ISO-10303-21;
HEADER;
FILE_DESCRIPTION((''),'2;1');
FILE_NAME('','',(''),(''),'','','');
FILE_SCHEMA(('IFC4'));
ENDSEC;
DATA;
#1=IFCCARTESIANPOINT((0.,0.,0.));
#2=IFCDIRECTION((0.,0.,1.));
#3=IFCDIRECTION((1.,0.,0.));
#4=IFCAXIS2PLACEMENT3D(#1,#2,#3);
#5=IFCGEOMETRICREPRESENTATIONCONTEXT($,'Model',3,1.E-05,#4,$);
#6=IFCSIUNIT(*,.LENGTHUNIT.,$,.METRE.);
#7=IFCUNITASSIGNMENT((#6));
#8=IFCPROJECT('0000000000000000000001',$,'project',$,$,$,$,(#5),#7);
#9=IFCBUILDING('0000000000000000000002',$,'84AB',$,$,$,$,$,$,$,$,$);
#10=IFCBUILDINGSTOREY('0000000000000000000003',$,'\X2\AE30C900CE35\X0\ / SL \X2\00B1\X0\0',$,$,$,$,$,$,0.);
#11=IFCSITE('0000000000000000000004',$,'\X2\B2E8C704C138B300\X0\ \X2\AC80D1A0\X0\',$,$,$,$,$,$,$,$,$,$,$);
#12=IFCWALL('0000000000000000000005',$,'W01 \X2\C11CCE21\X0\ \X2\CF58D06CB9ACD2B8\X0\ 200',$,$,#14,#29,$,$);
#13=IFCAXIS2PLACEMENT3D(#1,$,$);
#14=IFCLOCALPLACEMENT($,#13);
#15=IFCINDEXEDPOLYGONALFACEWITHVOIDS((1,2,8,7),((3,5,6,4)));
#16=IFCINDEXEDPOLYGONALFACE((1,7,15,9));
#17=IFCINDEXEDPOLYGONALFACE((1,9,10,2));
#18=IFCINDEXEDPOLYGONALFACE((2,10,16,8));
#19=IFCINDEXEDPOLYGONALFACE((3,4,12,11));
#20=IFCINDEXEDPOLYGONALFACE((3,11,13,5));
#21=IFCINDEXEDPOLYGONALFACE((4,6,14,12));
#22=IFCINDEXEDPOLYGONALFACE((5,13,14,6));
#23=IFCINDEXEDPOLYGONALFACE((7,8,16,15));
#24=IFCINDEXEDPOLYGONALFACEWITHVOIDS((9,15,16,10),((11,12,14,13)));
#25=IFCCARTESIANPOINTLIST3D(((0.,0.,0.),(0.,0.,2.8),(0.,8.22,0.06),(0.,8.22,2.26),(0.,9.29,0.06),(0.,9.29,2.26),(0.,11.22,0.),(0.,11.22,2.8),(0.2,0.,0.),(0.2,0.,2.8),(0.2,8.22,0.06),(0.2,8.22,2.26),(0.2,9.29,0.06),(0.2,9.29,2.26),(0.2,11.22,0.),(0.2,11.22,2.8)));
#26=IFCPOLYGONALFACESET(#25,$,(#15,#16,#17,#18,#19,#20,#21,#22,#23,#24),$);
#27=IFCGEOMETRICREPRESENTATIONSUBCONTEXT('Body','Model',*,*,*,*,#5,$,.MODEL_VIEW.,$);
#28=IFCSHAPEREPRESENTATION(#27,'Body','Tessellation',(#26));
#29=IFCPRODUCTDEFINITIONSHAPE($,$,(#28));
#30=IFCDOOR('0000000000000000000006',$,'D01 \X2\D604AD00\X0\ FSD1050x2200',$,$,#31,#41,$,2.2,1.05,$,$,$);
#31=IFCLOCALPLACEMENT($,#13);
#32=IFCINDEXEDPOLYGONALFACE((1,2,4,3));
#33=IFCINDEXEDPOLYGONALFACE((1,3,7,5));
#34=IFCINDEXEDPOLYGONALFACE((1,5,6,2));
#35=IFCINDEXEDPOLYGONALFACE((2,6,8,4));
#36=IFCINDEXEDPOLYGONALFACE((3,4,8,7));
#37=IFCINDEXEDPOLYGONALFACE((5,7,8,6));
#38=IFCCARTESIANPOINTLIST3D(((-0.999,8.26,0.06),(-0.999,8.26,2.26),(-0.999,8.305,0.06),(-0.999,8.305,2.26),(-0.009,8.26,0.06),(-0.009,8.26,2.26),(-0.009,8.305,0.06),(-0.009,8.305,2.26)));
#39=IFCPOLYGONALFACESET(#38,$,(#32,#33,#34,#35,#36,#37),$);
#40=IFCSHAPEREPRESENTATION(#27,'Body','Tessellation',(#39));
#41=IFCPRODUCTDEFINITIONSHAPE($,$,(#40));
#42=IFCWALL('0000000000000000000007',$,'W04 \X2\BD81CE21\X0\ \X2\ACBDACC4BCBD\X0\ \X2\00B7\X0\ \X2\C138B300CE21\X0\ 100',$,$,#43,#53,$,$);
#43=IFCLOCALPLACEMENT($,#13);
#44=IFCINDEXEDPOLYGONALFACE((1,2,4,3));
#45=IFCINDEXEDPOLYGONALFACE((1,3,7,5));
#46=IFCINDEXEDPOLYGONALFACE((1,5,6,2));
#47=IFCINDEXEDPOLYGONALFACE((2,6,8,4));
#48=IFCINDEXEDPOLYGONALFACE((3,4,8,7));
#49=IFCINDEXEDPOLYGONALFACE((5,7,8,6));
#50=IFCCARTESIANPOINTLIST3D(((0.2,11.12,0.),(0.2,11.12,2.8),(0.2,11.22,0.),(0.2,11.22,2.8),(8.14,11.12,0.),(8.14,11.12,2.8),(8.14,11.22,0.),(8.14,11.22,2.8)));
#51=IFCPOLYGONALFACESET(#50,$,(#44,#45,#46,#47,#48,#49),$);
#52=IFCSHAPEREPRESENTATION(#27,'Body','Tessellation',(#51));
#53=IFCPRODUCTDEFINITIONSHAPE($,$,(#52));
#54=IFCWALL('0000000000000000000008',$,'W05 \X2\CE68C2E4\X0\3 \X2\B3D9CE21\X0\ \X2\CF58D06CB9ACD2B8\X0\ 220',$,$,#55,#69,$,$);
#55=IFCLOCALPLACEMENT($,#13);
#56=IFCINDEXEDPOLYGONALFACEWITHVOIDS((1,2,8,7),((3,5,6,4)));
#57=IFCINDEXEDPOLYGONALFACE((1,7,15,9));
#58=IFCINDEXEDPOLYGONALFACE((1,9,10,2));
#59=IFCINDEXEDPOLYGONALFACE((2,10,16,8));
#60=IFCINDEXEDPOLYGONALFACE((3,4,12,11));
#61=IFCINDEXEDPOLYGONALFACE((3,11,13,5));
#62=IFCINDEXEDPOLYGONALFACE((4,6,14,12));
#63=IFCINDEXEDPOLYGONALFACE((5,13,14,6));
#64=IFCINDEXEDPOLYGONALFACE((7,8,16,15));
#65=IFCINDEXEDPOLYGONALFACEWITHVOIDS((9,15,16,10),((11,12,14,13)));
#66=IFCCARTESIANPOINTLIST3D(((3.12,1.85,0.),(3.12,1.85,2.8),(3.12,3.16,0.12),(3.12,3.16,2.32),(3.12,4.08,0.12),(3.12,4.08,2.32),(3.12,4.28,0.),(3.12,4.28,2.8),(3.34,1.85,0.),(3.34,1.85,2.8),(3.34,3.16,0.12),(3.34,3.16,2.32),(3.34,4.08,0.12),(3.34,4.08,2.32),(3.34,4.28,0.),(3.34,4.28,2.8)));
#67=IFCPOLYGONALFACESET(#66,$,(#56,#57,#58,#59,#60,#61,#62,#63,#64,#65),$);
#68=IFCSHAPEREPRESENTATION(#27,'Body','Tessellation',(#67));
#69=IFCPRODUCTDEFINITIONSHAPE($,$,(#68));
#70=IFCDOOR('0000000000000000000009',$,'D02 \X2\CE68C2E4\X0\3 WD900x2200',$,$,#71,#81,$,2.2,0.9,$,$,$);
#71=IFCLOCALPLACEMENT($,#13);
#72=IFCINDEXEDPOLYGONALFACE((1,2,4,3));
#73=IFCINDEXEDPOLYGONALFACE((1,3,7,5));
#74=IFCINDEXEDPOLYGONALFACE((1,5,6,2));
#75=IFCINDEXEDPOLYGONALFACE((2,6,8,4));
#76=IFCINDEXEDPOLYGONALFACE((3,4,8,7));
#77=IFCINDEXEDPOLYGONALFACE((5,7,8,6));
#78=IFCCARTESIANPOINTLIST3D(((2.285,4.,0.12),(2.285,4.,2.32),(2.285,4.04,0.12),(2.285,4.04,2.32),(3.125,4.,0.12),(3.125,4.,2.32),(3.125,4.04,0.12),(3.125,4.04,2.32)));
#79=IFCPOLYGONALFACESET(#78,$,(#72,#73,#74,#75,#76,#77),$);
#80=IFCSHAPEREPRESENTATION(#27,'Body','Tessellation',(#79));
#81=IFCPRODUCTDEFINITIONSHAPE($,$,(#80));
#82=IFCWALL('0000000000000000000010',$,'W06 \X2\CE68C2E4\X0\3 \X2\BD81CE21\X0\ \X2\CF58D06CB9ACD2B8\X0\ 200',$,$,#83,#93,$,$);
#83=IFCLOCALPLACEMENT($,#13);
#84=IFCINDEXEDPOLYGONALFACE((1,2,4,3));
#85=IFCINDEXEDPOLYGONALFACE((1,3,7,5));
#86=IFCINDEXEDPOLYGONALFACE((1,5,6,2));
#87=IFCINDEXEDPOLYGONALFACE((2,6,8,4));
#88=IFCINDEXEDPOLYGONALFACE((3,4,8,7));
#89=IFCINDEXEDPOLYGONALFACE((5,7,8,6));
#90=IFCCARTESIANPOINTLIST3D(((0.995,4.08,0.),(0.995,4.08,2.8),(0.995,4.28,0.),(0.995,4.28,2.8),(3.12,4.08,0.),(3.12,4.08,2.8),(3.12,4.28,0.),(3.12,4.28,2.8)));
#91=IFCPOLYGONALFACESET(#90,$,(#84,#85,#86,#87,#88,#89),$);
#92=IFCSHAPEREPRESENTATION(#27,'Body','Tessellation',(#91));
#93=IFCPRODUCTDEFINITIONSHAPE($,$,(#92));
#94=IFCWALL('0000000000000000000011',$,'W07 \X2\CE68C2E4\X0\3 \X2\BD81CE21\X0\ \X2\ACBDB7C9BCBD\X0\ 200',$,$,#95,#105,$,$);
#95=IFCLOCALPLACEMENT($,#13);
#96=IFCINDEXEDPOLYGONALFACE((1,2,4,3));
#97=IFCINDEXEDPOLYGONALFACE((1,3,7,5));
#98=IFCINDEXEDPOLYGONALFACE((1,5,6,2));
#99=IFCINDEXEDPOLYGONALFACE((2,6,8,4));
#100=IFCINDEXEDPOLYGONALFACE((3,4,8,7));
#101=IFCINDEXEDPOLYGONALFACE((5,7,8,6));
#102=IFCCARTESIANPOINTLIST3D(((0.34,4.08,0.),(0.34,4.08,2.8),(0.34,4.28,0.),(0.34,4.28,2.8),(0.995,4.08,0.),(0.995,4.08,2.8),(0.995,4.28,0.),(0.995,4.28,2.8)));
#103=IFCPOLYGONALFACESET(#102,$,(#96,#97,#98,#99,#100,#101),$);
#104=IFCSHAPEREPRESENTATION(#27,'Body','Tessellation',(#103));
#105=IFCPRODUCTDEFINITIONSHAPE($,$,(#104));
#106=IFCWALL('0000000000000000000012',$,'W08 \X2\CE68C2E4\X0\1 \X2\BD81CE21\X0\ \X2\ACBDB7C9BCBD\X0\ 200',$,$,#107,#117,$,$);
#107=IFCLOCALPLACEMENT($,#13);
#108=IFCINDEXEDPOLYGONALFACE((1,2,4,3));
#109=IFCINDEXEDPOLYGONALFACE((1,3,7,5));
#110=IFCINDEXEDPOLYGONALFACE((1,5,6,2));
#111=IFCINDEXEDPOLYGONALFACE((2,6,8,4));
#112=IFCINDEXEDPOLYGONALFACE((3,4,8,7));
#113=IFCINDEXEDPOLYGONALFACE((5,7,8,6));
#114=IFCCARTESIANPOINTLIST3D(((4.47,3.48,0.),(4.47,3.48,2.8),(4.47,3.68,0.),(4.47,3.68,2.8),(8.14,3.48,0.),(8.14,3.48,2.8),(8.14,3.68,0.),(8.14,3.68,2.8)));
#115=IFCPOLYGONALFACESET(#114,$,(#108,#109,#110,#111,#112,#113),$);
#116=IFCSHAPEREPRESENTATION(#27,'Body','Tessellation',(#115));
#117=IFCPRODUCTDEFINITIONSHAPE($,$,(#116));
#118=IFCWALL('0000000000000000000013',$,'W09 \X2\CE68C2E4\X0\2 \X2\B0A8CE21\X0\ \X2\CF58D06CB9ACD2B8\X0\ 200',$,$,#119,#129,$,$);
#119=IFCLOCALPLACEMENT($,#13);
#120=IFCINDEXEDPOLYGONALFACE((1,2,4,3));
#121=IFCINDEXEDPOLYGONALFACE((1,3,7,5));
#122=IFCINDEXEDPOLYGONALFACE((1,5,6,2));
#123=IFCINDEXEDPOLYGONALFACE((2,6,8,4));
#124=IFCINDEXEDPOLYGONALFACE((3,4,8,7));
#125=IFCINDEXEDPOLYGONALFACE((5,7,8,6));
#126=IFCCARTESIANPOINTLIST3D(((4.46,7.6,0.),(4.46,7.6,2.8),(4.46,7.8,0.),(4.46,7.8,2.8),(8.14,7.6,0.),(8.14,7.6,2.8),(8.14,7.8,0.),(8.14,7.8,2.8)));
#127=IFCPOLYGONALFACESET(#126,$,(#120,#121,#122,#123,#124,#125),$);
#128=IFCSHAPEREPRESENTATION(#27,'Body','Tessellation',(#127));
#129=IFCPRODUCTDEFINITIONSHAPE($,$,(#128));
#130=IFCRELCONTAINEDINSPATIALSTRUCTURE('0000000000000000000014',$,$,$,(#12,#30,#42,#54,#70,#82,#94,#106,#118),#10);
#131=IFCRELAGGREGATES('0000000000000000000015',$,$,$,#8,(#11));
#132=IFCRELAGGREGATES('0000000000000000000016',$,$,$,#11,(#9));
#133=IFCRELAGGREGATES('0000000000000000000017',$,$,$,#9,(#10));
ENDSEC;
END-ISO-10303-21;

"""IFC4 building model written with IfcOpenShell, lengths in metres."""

from ifc_helpers import new_model, si_unit, frame, origin, origin_with_axes, place, context, subcontext, project, spatial, polyline, outline, extrude, element, fill, save


model = new_model("IFC4")

# Units and contexts
model_context = context("Model", 3, precision=1e-05, world=origin_with_axes())
body_context = subcontext(model_context, "Body", "Model", "MODEL_VIEW")
ifc_project = project(units=[si_unit("LENGTHUNIT", "METRE")], contexts=[model_context])

# Site, building, storey
site = spatial("IfcSite", under=ifc_project, Name="단위세대 검토")
building = spatial("IfcBuilding", under=site, Name="84AB")
storey = spatial("IfcBuildingStorey", under=building, Name="기준층 / SL ±0", Elevation=0.0)

# Wall, opening, door
wall_1_placement = place(None, origin_with_axes())
wall_1 = element("IfcWall", 1, at=wall_1_placement, inside=storey, Name="W01 서측 콘크리트 200", context=body_context, shape_type="SweptSolid", body=[
    extrude(outline(polyline([(0.2, 0.0), (0.2, 11.22), (0.0, 11.22), (0.0, 0.0), (0.2, 0.0)])), origin(), (0.0, 0.0, 1.0), 2.8),
])
opening_1_placement = place(wall_1_placement, origin_with_axes())
opening_1 = element("IfcOpeningElement", 2, at=opening_1_placement, cuts=wall_1, context=body_context, shape_type="SweptSolid", body=[
    extrude(outline(polyline([(0.201, 8.22), (0.201, 9.29), (-0.001, 9.29), (-0.001, 8.22), (0.201, 8.22)])), frame((0.0, 0.0, 0.06)), (0.0, 0.0, 1.0), 2.2),
])
door_1_placement = place(None, origin_with_axes())
door_1 = element("IfcDoor", 3, at=door_1_placement, inside=storey, Name="D01 현관 FSD1050x2200", OverallHeight=2.2, OverallWidth=1.05, context=body_context, shape_type="SweptSolid", body=[
    extrude(outline(polyline([(-0.009, 8.305), (-0.999, 8.305), (-0.999, 8.26), (-0.009, 8.26), (-0.009, 8.305)])), frame((0.0, 0.0, 0.06)), (0.0, 0.0, 1.0), 2.2),
])
fill(opening_1, door_1)

# Wall
wall_2_placement = place(None, origin_with_axes())
element("IfcWall", 4, at=wall_2_placement, inside=storey, Name="W04 북측 경계벽 · 세대측 100", context=body_context, shape_type="SweptSolid", body=[
    extrude(outline(polyline([(8.14, 11.12), (8.14, 11.22), (0.2, 11.22), (0.2, 11.12), (8.14, 11.12)])), origin(), (0.0, 0.0, 1.0), 2.8),
])

# Wall, opening, door
wall_3_placement = place(None, origin_with_axes())
wall_3 = element("IfcWall", 5, at=wall_3_placement, inside=storey, Name="W05 침실3 동측 콘크리트 220", context=body_context, shape_type="SweptSolid", body=[
    extrude(outline(polyline([(3.34, 1.85), (3.34, 4.28), (3.12, 4.28), (3.12, 1.85), (3.34, 1.85)])), origin(), (0.0, 0.0, 1.0), 2.8),
])
opening_2_placement = place(wall_3_placement, origin_with_axes())
opening_2 = element("IfcOpeningElement", 6, at=opening_2_placement, cuts=wall_3, context=body_context, shape_type="SweptSolid", body=[
    extrude(outline(polyline([(3.341, 3.16), (3.341, 4.08), (3.119, 4.08), (3.119, 3.16), (3.341, 3.16)])), frame((0.0, 0.0, 0.12)), (0.0, 0.0, 1.0), 2.2),
])
door_2_placement = place(None, origin_with_axes())
door_2 = element("IfcDoor", 7, at=door_2_placement, inside=storey, Name="D02 침실3 WD900x2200", OverallHeight=2.2, OverallWidth=0.9, context=body_context, shape_type="SweptSolid", body=[
    extrude(outline(polyline([(3.125, 4.0), (3.125, 4.04), (2.285, 4.04), (2.285, 4.0), (3.125, 4.0)])), frame((0.0, 0.0, 0.12)), (0.0, 0.0, 1.0), 2.2),
])
fill(opening_2, door_2)

# Walls
wall_4_placement = place(None, origin_with_axes())
element("IfcWall", 8, at=wall_4_placement, inside=storey, Name="W06 침실3 북측 콘크리트 200", context=body_context, shape_type="SweptSolid", body=[
    extrude(outline(polyline([(3.12, 4.08), (3.12, 4.28), (0.995, 4.28), (0.995, 4.08), (3.12, 4.08)])), origin(), (0.0, 0.0, 1.0), 2.8),
])
wall_5_placement = place(None, origin_with_axes())
element("IfcWall", 9, at=wall_5_placement, inside=storey, Name="W07 침실3 북측 경량벽 200", context=body_context, shape_type="SweptSolid", body=[
    extrude(outline(polyline([(0.995, 4.08), (0.995, 4.28), (0.34, 4.28), (0.34, 4.08), (0.995, 4.08)])), origin(), (0.0, 0.0, 1.0), 2.8),
])
wall_6_placement = place(None, origin_with_axes())
element("IfcWall", 10, at=wall_6_placement, inside=storey, Name="W08 침실1 북측 경량벽 200", context=body_context, shape_type="SweptSolid", body=[
    extrude(outline(polyline([(8.14, 3.48), (8.14, 3.68), (4.47, 3.68), (4.47, 3.48), (8.14, 3.48)])), origin(), (0.0, 0.0, 1.0), 2.8),
])
wall_7_placement = place(None, origin_with_axes())
element("IfcWall", 11, at=wall_7_placement, inside=storey, Name="W09 침실2 남측 콘크리트 200", context=body_context, shape_type="SweptSolid", body=[
    extrude(outline(polyline([(8.14, 7.6), (8.14, 7.8), (4.46, 7.8), (4.46, 7.6), (8.14, 7.6)])), origin(), (0.0, 0.0, 1.0), 2.8),
])

save(model, "model.ifc")
